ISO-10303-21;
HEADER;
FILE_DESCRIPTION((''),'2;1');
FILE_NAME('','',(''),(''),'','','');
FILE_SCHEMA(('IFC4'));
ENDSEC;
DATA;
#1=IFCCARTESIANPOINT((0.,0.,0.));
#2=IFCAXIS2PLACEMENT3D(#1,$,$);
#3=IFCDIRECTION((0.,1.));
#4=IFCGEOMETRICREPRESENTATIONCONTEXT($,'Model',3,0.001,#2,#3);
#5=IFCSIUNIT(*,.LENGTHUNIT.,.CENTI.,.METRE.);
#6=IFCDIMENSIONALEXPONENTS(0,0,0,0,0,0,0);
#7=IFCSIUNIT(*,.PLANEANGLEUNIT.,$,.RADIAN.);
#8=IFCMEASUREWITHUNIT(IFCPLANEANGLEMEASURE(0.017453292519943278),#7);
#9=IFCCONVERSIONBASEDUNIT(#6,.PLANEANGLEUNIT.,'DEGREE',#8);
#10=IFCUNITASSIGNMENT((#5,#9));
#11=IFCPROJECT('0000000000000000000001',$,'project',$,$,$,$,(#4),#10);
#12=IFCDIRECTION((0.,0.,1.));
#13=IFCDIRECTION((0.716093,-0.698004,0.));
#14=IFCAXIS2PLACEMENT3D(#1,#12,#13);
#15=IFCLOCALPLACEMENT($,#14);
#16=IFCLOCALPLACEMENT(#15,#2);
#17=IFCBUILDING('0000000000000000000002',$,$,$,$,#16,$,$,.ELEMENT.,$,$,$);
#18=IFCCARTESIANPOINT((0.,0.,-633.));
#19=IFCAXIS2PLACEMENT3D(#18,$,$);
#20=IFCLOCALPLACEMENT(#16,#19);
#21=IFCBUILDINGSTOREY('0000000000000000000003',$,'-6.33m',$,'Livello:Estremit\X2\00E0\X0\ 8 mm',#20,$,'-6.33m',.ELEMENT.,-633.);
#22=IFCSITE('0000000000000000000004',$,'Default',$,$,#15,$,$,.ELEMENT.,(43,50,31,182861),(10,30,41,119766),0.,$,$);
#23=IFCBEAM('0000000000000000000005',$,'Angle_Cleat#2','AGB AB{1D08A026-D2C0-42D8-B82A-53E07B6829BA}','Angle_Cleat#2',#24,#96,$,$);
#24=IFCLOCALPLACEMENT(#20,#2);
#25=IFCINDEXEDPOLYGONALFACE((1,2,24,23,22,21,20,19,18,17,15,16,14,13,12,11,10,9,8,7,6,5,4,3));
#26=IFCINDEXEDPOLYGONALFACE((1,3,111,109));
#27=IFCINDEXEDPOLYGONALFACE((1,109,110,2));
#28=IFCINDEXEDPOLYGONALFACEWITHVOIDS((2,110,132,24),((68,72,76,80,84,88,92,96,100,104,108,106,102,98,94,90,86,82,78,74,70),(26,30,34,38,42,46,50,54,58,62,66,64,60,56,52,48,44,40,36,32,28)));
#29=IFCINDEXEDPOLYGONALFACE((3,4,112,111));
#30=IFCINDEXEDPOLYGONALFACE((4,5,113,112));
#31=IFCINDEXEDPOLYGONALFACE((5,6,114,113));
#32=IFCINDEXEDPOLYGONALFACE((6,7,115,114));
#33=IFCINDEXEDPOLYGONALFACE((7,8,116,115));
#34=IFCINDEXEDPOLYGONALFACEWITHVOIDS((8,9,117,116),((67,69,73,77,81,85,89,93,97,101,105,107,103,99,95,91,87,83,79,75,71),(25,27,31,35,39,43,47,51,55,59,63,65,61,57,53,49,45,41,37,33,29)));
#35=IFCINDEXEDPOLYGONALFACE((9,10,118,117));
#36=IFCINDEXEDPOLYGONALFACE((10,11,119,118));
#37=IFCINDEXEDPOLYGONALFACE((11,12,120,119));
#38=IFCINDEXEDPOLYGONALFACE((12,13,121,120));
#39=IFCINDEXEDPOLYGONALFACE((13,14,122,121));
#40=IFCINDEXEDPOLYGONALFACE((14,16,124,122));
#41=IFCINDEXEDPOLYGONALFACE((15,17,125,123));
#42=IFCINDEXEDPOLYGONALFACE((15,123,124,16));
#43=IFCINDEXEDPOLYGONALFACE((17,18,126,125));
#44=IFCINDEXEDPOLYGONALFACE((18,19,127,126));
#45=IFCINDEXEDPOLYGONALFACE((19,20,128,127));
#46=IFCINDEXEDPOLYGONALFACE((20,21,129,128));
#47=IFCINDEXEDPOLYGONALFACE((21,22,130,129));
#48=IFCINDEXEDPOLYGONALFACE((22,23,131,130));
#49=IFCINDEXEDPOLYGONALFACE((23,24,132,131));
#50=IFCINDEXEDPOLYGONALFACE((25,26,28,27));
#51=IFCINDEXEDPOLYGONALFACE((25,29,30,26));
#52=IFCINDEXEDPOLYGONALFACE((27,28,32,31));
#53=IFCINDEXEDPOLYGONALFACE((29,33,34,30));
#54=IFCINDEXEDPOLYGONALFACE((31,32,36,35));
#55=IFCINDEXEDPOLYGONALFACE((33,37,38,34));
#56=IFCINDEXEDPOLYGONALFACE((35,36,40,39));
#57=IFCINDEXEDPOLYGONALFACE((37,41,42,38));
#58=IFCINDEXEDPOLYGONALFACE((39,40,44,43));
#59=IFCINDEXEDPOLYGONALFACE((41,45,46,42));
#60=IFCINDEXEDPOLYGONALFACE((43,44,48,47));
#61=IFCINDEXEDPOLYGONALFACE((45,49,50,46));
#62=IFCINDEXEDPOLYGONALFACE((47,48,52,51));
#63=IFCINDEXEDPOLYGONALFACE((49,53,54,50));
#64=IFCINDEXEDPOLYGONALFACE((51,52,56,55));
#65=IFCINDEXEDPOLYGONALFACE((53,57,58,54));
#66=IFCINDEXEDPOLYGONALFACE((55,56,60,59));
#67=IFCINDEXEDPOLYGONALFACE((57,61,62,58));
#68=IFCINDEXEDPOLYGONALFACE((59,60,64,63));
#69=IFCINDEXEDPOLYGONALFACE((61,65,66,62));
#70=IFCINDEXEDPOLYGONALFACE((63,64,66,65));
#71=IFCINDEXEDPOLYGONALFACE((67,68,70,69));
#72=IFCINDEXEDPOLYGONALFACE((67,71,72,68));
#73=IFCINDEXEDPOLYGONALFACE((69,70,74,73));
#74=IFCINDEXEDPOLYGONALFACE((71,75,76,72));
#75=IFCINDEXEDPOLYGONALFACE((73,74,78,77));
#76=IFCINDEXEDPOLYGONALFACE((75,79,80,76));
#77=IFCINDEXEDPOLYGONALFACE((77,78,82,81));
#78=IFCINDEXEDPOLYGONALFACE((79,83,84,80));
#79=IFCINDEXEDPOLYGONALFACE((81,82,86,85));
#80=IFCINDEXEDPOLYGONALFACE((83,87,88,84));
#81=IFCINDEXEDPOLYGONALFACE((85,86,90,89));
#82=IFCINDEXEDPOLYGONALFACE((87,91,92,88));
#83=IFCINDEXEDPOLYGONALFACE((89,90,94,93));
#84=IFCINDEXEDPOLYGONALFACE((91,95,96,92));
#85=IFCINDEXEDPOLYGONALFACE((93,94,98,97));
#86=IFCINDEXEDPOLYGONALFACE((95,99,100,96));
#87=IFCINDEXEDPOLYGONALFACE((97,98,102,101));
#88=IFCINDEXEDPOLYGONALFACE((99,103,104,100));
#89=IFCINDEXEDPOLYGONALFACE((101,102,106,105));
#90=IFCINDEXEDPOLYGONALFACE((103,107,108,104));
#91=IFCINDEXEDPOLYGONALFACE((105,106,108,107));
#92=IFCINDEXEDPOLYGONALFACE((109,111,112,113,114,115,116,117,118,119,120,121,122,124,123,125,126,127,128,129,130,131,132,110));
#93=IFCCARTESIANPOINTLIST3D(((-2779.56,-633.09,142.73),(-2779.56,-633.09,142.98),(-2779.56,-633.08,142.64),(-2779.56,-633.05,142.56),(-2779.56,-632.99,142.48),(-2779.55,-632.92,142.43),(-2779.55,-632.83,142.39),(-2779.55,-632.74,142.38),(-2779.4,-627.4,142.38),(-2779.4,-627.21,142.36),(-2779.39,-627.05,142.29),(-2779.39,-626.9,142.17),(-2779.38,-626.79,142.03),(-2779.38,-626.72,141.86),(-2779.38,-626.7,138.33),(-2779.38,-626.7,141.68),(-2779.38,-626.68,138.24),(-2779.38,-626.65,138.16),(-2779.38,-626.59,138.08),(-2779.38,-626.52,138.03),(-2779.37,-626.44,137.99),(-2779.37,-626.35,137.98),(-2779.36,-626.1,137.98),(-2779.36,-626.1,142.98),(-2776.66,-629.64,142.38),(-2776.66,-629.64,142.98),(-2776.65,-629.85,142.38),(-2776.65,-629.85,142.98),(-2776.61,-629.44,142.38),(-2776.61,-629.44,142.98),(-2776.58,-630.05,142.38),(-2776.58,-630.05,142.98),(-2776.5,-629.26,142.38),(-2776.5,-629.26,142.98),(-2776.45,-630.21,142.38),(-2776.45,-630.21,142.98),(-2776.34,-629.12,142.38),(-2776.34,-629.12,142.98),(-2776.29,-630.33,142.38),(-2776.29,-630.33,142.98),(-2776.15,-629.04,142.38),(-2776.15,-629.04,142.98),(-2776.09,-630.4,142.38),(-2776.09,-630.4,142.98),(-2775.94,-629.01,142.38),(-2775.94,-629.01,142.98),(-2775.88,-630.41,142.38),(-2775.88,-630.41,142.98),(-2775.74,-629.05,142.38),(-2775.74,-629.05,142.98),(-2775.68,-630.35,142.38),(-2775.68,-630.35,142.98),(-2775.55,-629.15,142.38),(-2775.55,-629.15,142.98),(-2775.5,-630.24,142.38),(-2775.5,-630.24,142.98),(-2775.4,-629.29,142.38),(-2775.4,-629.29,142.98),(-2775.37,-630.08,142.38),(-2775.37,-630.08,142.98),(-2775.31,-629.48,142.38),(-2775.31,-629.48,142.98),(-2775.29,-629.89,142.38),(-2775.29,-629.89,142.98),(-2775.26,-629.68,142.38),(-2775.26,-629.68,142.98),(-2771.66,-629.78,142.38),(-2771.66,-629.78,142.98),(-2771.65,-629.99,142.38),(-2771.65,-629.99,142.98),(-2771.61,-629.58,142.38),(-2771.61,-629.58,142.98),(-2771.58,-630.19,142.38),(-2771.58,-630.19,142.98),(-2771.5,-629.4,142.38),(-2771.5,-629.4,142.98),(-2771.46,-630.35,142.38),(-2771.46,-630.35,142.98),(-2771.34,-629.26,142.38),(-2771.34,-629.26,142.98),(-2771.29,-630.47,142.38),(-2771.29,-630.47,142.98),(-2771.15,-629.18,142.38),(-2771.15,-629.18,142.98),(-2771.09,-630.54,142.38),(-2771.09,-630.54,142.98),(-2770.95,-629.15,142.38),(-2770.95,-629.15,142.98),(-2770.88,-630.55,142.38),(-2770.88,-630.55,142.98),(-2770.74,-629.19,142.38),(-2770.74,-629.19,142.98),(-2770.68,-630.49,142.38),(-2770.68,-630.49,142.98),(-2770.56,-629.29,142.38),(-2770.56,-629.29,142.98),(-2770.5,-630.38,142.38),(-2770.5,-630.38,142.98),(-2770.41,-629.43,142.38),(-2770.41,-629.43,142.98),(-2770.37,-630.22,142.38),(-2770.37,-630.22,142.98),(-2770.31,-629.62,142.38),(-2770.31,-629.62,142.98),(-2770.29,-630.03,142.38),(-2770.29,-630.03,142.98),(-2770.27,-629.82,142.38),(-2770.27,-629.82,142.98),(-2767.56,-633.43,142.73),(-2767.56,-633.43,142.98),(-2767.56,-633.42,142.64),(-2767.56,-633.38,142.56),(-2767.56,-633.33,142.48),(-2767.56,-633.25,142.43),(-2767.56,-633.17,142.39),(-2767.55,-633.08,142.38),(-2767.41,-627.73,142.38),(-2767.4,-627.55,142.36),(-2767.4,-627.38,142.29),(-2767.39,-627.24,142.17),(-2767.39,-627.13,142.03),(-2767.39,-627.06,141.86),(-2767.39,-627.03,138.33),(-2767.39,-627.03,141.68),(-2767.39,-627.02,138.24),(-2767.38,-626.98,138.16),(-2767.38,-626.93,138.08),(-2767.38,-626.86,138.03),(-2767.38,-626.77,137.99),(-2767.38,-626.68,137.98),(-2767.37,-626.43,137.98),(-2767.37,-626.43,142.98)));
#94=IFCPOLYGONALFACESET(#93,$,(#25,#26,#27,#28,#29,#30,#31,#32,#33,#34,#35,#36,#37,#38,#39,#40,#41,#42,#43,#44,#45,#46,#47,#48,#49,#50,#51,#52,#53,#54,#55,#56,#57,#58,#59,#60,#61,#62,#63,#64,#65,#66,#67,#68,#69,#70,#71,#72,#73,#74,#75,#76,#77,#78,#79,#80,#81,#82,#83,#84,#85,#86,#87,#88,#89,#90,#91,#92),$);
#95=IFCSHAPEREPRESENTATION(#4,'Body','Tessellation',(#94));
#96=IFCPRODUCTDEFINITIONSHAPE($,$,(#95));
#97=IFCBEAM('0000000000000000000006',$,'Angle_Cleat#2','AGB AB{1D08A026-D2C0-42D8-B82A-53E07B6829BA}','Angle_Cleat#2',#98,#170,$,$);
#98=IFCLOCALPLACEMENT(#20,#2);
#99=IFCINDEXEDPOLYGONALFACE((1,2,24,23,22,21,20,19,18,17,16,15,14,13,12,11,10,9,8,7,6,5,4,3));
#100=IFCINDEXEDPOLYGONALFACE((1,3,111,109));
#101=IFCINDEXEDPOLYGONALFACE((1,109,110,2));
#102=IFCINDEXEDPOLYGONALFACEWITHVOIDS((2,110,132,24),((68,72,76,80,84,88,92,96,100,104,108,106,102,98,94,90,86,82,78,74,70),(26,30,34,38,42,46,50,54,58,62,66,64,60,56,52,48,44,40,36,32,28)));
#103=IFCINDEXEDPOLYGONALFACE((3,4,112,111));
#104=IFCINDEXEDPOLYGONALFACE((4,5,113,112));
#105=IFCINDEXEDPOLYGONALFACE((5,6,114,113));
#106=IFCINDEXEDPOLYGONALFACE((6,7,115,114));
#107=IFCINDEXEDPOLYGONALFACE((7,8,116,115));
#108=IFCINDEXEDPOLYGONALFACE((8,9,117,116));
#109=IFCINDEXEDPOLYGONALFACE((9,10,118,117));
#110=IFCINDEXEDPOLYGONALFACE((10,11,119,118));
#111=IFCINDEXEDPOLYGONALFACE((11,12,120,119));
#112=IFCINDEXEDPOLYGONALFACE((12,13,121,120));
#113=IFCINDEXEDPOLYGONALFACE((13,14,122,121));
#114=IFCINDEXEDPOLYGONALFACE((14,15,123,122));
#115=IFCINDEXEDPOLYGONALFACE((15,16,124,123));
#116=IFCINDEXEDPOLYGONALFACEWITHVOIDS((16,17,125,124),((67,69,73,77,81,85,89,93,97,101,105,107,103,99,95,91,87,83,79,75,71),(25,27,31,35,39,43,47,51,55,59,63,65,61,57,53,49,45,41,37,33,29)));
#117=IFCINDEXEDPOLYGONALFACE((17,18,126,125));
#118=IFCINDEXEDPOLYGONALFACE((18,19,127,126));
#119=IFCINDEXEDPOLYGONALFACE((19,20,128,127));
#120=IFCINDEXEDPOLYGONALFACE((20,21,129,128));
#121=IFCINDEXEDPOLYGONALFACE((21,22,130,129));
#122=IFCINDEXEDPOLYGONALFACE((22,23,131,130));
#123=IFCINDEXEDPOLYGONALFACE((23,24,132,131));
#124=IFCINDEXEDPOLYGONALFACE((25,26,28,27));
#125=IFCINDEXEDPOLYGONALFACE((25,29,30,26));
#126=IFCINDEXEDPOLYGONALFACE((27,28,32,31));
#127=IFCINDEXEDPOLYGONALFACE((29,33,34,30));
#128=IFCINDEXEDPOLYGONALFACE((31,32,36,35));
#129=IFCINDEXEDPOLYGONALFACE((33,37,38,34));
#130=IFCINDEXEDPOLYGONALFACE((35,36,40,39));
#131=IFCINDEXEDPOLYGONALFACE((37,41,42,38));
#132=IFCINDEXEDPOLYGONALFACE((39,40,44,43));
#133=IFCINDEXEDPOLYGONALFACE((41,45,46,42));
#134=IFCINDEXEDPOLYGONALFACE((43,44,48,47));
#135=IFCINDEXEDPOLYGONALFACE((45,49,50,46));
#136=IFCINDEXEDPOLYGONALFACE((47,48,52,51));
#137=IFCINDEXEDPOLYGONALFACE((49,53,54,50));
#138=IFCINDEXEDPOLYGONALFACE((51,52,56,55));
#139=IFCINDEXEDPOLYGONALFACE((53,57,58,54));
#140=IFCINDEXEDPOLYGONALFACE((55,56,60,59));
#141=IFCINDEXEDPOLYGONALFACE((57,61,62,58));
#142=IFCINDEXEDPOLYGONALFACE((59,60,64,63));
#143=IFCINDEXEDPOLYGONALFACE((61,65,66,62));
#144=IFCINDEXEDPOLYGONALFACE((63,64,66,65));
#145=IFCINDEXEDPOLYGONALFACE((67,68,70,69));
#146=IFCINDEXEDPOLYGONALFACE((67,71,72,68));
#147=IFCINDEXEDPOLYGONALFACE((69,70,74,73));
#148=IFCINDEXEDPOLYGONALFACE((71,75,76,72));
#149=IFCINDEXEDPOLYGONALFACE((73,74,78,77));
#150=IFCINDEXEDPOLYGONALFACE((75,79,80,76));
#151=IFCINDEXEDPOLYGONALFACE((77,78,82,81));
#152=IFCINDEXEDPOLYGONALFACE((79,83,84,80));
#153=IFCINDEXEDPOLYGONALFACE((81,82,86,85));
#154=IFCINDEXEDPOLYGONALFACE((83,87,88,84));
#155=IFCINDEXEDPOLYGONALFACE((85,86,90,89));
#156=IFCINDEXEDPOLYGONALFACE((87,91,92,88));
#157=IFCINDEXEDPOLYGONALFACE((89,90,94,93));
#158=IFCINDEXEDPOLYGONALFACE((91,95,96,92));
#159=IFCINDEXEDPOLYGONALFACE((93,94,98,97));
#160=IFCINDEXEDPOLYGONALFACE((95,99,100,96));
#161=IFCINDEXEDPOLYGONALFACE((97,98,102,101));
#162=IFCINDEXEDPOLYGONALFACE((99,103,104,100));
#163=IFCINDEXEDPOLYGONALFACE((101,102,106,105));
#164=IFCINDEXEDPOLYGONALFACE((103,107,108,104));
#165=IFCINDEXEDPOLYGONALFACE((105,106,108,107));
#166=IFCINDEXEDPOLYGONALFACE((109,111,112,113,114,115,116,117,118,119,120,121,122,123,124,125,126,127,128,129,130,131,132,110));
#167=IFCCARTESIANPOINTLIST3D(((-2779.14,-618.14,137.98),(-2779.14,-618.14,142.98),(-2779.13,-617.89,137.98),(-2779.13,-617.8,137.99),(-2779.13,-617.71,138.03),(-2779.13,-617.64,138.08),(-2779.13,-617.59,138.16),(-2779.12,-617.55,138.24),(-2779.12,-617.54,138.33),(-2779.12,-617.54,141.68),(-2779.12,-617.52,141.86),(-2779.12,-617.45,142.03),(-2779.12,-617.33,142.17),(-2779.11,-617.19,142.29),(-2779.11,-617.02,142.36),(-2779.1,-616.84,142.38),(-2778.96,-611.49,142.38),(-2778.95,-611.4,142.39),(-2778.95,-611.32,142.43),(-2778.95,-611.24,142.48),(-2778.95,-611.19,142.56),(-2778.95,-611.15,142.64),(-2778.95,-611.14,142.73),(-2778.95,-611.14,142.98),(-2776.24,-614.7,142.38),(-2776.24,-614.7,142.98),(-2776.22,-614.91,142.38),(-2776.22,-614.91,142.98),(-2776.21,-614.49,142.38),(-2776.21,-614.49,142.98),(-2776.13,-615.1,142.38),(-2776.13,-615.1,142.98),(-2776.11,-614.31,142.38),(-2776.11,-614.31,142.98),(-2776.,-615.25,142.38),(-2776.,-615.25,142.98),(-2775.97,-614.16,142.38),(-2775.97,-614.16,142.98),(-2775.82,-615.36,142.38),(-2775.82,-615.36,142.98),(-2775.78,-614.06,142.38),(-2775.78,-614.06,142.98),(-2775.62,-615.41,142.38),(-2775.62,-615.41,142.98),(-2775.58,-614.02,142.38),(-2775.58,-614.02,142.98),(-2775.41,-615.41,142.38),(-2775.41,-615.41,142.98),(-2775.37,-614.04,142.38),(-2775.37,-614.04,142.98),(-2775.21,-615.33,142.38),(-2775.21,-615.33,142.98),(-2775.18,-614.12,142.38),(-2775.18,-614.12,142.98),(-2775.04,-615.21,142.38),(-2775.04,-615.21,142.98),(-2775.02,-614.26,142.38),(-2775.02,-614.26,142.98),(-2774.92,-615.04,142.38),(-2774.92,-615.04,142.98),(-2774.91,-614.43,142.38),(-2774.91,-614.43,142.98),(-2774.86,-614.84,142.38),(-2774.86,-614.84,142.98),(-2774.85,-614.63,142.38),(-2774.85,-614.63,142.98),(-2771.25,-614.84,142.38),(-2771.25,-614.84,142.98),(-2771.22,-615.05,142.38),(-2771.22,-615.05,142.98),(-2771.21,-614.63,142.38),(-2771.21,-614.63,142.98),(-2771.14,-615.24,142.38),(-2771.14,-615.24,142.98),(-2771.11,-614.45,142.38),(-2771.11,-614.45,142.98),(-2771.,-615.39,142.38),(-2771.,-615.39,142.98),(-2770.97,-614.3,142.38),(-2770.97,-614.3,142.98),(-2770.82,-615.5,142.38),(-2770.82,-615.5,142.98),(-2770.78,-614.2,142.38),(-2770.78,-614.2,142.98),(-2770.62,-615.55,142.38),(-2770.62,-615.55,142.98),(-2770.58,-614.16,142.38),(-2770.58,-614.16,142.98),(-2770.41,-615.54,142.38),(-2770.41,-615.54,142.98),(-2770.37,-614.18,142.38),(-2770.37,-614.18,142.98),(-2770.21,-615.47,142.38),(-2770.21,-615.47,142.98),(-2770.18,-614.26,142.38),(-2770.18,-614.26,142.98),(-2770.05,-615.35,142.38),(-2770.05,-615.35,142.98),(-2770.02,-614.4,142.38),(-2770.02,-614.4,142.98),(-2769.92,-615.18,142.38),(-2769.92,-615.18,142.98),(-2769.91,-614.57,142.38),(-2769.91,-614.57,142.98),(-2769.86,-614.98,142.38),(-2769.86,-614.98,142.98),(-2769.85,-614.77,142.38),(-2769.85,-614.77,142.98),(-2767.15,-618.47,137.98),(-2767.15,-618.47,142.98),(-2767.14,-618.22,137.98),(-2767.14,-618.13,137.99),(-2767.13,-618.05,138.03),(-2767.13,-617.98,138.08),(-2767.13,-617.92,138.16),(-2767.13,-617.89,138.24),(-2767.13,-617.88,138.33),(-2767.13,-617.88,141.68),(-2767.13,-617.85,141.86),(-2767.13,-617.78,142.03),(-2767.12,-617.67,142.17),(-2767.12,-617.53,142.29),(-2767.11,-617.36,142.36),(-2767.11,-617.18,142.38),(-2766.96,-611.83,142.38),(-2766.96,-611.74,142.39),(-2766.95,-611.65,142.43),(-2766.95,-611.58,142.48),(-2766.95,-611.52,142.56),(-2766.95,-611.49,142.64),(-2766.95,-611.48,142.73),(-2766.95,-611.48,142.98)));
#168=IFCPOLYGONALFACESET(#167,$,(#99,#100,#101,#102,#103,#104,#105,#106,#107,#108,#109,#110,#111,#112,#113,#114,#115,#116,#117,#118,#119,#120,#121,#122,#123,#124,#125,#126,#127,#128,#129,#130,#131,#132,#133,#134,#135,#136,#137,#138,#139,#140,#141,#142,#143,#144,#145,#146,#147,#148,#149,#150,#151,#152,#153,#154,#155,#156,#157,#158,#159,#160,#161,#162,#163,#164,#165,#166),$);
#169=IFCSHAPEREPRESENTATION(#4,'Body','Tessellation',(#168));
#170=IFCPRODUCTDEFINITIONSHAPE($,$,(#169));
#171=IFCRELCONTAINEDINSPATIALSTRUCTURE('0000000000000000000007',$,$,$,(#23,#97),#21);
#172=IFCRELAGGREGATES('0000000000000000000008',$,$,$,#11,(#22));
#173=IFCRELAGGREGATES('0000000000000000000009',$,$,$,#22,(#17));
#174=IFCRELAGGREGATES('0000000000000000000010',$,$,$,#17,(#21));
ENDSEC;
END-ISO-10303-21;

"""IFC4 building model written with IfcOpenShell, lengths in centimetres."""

from ifc_helpers import new_model, entity, si_unit, converted_unit, direction, frame, frame_2d, origin, place, context, project, spatial, circle, l_section, extrude, element, save


model = new_model("IFC4")

# Units and contexts
model_context = context("Model", 3, precision=0.001, world=origin(), true_north=direction((0.0, 1.0)))
ifc_project = project(units=[si_unit("LENGTHUNIT", "METRE", prefix="CENTI"), converted_unit("PLANEANGLEUNIT", "DEGREE", entity("IfcPlaneAngleMeasure", 0.017453292519943278), si_unit("PLANEANGLEUNIT", "RADIAN"), dimensions=[0, 0, 0, 0, 0, 0, 0])], contexts=[model_context])

# Site, building, storey
site_placement = place(None, frame((0.0, 0.0, 0.0), z_axis=(0.0, 0.0, 1.0), x_axis=(0.716093, -0.698004, 0.0)))
site = spatial("IfcSite", under=ifc_project, at=site_placement, Name="Default", CompositionType="ELEMENT", RefLatitude=(43, 50, 31, 182861), RefLongitude=(10, 30, 41, 119766), RefElevation=0.0)
building_placement = place(site_placement, origin())
building = spatial("IfcBuilding", under=site, at=building_placement, CompositionType="ELEMENT")
storey_placement = place(building_placement, frame((0.0, 0.0, -633.0)))
storey = spatial("IfcBuildingStorey", under=building, at=storey_placement, Name="-6.33m", ObjectType="Livello:Estremità 8 mm", LongName="-6.33m", CompositionType="ELEMENT", Elevation=-633.0)

# Beams, openings
beam_1_placement = place(storey_placement, frame((-2779.43, -628.35, 141.75), z_axis=(0.999608, -0.02798, 0.0), x_axis=(-0.02798, -0.999608, 0.0)))
beam_1 = element("IfcBeam", 1, at=beam_1_placement, inside=storey, Name="Angle_Cleat#2", Description="AGB AB{1D08A026-D2C0-42D8-B82A-53E07B6829BA}", ObjectType="Angle_Cleat#2", context=model_context, shape_type="SweptSolid", body=[
    extrude(l_section(Depth=5.0, Width=7.0, Thickness=0.6, FilletRadius=0.7, EdgeRadius=0.35, at=frame_2d((1.25, 1.27))), origin(), (0.0, 0.0, 1.0), 12.0),
])
opening_1_placement = place(beam_1_placement, frame((1.27, -0.6, 4.2), z_axis=(0.0, 1.0, 0.0), x_axis=(-1.0, 0.0, 0.0)))
element("IfcOpeningElement", 2, at=opening_1_placement, cuts=beam_1, ObjectType="Opening", context=model_context, shape_type="SweptSolid", body=[
    extrude(circle(Radius=0.7, at=frame_2d((0.0, -0.7), x_axis=(1.0, 0.0))), origin(), (0.0, 0.0, -1.0), 0.7),
])
opening_2_placement = place(beam_1_placement, frame((1.27, -0.6, 9.2), z_axis=(0.0, 1.0, 0.0), x_axis=(-1.0, 0.0, 0.0)))
element("IfcOpeningElement", 3, at=opening_2_placement, cuts=beam_1, ObjectType="Opening", context=model_context, shape_type="SweptSolid", body=[
    extrude(circle(Radius=0.7, at=frame_2d((0.0, -0.7), x_axis=(1.0, 0.0))), origin(), (0.0, 0.0, -1.0), 0.7),
])
beam_2_placement = place(storey_placement, frame((-2779.08, -615.89, 141.75), z_axis=(-0.999608, 0.02798, 0.0), x_axis=(0.02798, 0.999608, 0.0)))
beam_2 = element("IfcBeam", 4, at=beam_2_placement, inside=storey, Name="Angle_Cleat#2", Description="AGB AB{1D08A026-D2C0-42D8-B82A-53E07B6829BA}", ObjectType="Angle_Cleat#2", context=model_context, shape_type="SweptSolid", body=[
    extrude(l_section(Depth=5.0, Width=7.0, Thickness=0.6, FilletRadius=0.7, EdgeRadius=0.35, at=frame_2d((1.25, 1.27))), origin(), (0.0, 0.0, -1.0), 12.0),
])
opening_3_placement = place(beam_2_placement, frame((1.27, -0.6, -6.0), z_axis=(0.0, -1.0, 0.0), x_axis=(0.0, 0.0, 1.0)))
element("IfcOpeningElement", 5, at=opening_3_placement, cuts=beam_2, ObjectType="Opening", context=model_context, shape_type="SweptSolid", body=[
    extrude(circle(Radius=0.7, at=frame_2d((2.5, 0.0), x_axis=(1.0, 0.0))), origin(), (0.0, 0.0, 1.0), 0.7),
])
opening_4_placement = place(beam_2_placement, frame((1.27, -0.6, -6.0), z_axis=(0.0, -1.0, 0.0), x_axis=(0.0, 0.0, 1.0)))
element("IfcOpeningElement", 6, at=opening_4_placement, cuts=beam_2, ObjectType="Opening", context=model_context, shape_type="SweptSolid", body=[
    extrude(circle(Radius=0.7, at=frame_2d((-2.5, 0.0), x_axis=(1.0, 0.0))), origin(), (0.0, 0.0, 1.0), 0.7),
])

save(model, "model.ifc")
